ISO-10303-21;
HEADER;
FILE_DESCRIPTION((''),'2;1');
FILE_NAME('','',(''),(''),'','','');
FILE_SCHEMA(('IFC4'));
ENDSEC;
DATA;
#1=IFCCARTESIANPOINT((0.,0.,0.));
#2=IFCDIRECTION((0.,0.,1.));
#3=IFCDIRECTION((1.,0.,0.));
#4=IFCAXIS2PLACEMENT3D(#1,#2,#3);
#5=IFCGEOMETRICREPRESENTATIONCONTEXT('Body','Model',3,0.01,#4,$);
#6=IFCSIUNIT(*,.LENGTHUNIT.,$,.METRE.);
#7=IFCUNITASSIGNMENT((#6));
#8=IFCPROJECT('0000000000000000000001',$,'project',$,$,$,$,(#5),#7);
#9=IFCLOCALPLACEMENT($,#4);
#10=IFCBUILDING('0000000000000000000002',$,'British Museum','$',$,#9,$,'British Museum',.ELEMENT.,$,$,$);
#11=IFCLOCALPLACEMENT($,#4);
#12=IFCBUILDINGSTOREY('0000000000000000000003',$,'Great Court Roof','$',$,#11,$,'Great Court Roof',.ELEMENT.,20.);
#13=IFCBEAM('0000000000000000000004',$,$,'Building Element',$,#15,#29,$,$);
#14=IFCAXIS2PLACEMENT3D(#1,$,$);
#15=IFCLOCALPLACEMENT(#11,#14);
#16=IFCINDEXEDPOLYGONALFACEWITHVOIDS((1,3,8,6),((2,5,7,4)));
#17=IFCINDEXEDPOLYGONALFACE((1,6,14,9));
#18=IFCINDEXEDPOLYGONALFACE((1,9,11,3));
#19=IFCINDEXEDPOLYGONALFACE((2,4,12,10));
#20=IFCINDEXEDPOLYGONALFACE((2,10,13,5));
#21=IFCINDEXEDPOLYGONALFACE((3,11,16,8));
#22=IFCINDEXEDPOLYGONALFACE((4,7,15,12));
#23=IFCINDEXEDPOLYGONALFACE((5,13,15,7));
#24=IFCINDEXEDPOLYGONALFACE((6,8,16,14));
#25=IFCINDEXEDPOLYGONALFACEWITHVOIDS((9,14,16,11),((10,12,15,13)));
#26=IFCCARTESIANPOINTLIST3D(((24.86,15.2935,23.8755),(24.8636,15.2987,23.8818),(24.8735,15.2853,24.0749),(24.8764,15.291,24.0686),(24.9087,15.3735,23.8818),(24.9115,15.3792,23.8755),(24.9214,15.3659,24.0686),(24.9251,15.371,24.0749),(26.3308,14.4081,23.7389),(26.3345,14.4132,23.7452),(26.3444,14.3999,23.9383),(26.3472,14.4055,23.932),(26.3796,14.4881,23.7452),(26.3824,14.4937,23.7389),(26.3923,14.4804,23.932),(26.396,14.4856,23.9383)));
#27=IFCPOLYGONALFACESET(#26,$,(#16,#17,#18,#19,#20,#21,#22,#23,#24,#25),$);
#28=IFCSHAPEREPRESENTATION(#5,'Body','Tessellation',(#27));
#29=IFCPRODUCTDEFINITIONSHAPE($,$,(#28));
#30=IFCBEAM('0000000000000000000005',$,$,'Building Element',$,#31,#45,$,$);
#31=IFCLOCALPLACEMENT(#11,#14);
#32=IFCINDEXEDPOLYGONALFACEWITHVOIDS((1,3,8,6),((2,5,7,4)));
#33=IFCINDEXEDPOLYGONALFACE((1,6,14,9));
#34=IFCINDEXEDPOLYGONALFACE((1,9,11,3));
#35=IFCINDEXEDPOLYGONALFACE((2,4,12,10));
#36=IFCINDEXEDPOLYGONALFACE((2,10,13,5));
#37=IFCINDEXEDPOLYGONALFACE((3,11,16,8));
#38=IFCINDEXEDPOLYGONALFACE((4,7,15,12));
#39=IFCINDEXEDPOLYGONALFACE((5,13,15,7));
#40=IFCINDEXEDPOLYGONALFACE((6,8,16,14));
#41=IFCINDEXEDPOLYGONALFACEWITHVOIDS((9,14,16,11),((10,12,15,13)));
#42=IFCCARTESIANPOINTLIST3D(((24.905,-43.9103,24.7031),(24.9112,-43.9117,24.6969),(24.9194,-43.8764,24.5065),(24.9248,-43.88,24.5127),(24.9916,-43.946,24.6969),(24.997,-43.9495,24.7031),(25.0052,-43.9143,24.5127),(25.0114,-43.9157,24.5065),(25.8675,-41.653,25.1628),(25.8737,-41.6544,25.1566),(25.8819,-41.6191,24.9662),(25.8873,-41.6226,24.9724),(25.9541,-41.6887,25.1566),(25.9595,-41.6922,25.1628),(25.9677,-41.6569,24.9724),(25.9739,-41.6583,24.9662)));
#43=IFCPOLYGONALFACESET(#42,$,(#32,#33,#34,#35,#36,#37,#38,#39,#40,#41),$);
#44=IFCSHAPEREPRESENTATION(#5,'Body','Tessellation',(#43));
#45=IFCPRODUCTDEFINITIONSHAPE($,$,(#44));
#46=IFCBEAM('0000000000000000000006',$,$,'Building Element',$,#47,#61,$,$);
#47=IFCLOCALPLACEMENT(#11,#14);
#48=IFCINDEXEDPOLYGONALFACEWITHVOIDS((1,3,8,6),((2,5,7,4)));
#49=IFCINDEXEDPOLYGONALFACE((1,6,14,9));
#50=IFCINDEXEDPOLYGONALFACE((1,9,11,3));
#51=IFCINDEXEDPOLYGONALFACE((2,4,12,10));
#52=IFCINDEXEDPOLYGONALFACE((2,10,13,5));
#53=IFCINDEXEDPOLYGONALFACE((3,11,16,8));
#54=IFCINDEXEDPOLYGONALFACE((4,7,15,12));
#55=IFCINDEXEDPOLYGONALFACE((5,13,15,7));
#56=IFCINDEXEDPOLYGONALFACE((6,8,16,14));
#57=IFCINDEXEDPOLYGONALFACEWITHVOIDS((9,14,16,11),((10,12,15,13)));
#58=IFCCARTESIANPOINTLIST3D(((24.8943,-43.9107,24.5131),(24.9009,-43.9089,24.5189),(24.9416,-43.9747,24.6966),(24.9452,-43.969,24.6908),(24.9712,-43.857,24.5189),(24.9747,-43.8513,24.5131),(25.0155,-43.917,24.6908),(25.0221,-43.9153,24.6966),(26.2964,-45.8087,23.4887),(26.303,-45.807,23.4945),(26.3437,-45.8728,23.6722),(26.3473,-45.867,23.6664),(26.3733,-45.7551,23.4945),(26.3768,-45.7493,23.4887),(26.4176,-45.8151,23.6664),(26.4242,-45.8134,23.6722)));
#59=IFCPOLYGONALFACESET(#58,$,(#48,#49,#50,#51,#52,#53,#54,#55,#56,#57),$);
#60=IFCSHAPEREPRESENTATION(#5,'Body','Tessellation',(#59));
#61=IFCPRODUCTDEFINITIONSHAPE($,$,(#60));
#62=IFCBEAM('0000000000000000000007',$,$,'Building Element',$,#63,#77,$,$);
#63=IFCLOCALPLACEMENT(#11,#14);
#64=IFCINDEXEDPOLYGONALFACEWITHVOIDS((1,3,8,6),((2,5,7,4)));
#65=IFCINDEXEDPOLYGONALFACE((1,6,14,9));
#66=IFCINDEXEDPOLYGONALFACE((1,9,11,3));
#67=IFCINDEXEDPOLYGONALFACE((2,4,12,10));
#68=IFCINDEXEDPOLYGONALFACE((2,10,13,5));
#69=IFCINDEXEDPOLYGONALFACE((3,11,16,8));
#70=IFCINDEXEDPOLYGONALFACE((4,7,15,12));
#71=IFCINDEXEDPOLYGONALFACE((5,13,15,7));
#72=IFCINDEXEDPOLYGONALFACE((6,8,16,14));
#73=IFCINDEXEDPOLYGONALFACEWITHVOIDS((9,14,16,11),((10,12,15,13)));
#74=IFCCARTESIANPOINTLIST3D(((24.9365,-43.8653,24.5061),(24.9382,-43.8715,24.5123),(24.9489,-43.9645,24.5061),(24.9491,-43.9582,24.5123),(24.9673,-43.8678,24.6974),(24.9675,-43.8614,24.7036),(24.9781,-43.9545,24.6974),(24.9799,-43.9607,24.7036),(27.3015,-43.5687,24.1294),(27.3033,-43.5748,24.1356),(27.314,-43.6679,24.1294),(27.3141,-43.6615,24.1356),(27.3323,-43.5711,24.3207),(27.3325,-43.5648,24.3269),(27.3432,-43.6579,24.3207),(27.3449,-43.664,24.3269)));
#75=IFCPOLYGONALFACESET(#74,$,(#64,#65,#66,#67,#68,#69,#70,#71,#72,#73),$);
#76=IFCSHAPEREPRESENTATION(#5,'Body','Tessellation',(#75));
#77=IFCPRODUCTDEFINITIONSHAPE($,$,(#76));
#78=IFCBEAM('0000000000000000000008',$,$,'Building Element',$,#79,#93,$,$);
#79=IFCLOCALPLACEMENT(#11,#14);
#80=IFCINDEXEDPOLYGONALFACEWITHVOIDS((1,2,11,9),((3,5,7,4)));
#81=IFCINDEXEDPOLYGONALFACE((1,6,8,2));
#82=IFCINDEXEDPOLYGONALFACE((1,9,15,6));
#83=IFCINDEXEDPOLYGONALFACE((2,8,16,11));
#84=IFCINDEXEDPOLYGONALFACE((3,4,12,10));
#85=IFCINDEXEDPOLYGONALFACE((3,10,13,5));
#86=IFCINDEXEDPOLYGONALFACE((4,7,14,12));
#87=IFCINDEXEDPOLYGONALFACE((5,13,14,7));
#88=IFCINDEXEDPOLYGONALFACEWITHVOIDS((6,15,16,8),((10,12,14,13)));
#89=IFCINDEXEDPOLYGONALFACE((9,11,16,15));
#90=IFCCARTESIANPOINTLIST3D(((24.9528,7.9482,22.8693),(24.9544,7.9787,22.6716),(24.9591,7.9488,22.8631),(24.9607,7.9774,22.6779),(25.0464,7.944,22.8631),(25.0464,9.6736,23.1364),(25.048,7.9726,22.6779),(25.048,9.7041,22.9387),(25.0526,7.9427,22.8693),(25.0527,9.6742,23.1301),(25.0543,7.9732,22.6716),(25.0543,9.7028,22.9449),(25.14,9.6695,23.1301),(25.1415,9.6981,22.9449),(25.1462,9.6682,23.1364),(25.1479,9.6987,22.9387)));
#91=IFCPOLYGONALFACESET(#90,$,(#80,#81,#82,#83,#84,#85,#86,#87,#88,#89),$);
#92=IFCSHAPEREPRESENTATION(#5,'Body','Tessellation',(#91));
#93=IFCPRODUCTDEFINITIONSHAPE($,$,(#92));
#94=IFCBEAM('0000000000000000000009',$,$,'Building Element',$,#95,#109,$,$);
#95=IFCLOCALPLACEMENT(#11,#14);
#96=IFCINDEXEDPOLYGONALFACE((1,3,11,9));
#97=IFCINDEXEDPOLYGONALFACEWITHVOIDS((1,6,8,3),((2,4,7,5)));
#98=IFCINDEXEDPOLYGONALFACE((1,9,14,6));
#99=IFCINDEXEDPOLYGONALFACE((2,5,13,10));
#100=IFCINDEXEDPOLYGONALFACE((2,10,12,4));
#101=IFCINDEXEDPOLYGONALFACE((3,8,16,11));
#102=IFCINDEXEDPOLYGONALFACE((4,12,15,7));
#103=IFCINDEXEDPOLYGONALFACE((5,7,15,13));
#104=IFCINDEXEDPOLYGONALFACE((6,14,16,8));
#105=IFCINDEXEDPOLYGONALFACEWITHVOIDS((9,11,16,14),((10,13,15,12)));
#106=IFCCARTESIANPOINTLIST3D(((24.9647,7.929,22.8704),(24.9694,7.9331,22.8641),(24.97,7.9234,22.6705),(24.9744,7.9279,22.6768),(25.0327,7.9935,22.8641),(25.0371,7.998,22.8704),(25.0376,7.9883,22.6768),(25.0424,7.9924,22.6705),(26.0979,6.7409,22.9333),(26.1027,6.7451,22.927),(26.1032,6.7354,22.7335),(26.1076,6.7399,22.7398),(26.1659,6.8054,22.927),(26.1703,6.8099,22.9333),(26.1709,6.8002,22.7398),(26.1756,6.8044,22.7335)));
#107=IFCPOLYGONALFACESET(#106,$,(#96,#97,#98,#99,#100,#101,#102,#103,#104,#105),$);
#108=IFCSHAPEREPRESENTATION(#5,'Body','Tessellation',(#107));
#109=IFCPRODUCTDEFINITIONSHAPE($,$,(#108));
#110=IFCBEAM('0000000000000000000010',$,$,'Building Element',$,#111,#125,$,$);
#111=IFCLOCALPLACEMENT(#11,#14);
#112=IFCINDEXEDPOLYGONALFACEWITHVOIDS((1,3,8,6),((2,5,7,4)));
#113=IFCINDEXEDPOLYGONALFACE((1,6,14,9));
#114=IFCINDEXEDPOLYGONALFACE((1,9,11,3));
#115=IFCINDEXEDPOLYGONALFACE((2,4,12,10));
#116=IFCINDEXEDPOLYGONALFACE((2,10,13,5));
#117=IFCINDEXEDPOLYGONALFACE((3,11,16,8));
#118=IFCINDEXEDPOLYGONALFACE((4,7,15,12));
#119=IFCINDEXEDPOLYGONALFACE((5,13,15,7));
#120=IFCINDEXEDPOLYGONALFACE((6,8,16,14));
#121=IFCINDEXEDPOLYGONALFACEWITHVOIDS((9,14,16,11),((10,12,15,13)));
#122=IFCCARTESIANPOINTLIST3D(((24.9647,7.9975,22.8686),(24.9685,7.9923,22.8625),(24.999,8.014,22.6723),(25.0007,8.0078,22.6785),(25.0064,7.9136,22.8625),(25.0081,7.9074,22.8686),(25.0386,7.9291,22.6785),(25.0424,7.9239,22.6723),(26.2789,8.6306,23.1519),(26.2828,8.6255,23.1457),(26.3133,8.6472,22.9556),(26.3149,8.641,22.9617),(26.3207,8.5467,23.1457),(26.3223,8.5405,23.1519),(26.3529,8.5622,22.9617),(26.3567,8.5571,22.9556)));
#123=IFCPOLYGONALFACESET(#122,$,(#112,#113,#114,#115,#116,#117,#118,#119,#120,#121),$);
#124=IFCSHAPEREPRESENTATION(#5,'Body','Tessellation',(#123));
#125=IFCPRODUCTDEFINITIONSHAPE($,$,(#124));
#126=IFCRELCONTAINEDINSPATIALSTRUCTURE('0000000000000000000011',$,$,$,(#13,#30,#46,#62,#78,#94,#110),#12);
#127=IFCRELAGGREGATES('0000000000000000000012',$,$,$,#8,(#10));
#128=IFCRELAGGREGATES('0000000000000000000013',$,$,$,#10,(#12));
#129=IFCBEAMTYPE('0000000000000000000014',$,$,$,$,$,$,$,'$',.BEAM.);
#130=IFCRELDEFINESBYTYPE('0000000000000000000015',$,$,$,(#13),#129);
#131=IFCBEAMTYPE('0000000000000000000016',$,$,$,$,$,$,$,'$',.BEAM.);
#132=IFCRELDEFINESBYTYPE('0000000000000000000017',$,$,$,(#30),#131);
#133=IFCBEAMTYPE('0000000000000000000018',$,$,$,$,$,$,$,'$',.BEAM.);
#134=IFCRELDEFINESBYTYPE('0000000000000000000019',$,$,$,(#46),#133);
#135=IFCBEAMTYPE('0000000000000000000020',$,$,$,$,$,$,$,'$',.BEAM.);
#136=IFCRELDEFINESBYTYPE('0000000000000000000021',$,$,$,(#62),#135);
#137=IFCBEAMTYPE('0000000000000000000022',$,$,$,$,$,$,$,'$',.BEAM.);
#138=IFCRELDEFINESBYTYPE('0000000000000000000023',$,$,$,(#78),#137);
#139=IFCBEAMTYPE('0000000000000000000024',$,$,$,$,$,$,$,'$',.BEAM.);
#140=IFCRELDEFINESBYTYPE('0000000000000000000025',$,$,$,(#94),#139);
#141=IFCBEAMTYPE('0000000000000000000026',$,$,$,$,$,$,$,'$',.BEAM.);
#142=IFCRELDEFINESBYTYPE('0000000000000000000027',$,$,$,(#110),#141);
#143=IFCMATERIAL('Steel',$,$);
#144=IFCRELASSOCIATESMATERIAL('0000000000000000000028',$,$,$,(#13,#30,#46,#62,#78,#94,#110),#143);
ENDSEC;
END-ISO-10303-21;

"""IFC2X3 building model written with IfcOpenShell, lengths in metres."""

from ifc_helpers import new_model, si_unit, frame, origin_with_axes, origin_2d, place, context, project, spatial, hollow_rectangle, extrude, material, type_object, element, save


model = new_model("IFC2X3")

# Units and contexts
model_context = context("Model", 3, precision=0.01, world=origin_with_axes(), identifier="Body")
ifc_project = project(units=[si_unit("LENGTHUNIT", "METRE")], contexts=[model_context])

# Building, storey
building_placement = place(None, origin_with_axes())
building = spatial("IfcBuilding", under=ifc_project, at=building_placement, Name="British Museum", Description="$", LongName="British Museum", CompositionType="ELEMENT")
storey_placement = place(None, origin_with_axes())
storey = spatial("IfcBuildingStorey", under=building, at=storey_placement, Name="Great Court Roof", Description="$", LongName="Great Court Roof", CompositionType="ELEMENT", Elevation=20.0)

# Beams
ifc_material = material(Name="Steel")
beam_type_1 = type_object("IfcBeamType", ElementType="$", PredefinedType="BEAM")
beam_1_placement = place(None, origin_with_axes())
element("IfcBeam", 1, at=beam_1_placement, inside=storey, type_object=beam_type_1, material=ifc_material, Description="Building Element", context=model_context, shape_type="SweptSolid", body=[
    extrude(hollow_rectangle(XDim=0.1, YDim=0.2, WallThickness=0.0063, InnerFilletRadius=-0.0063, OuterFilletRadius=0.0, at=origin_2d()), frame((24.8925, 15.3323, 23.9752), z_axis=(0.85404, -0.514127, -0.079308), x_axis=(0.515752, 0.856738, 0.0)), (0.0, 0.0, 1.0), 1.7222),
])
beam_type_2 = type_object("IfcBeamType", ElementType="$", PredefinedType="BEAM")
beam_2_placement = place(None, origin_with_axes())
element("IfcBeam", 2, at=beam_2_placement, inside=storey, type_object=beam_type_2, material=ifc_material, Description="Building Element", context=model_context, shape_type="SweptSolid", body=[
    extrude(hollow_rectangle(XDim=0.1, YDim=0.2, WallThickness=0.0063, InnerFilletRadius=-0.0063, OuterFilletRadius=0.0, at=origin_2d()), frame((24.9582, -43.913, 24.6048), z_axis=(0.385525, 0.904145, 0.1841), x_axis=(-0.919868, 0.392229, 0.0)), (0.0, 0.0, 1.0), 2.4967),
])
beam_type_3 = type_object("IfcBeamType", ElementType="$", PredefinedType="BEAM")
beam_3_placement = place(None, origin_with_axes())
element("IfcBeam", 3, at=beam_3_placement, inside=storey, type_object=beam_type_3, material=ifc_material, Description="Building Element", context=model_context, shape_type="SweptSolid", body=[
    extrude(hollow_rectangle(XDim=0.1, YDim=0.2, WallThickness=0.0063, InnerFilletRadius=-0.0063, OuterFilletRadius=0.0, at=origin_2d()), frame((24.9582, -43.913, 24.6048), z_axis=(0.545026, -0.737824, -0.398199), x_axis=(0.804344, 0.594164, 0.0)), (0.0, 0.0, 1.0), 2.5725),
])
beam_type_4 = type_object("IfcBeamType", ElementType="$", PredefinedType="BEAM")
beam_4_placement = place(None, origin_with_axes())
element("IfcBeam", 4, at=beam_4_placement, inside=storey, type_object=beam_type_4, material=ifc_material, Description="Building Element", context=model_context, shape_type="SweptSolid", body=[
    extrude(hollow_rectangle(XDim=0.1, YDim=0.2, WallThickness=0.0063, InnerFilletRadius=-0.0063, OuterFilletRadius=0.0, at=origin_2d()), frame((24.9582, -43.913, 24.6048), z_axis=(0.980063, 0.122939, -0.156086), x_axis=(-0.124465, 0.992224, 0.0)), (0.0, 0.0, 1.0), 2.4131),
])
beam_type_5 = type_object("IfcBeamType", ElementType="$", PredefinedType="BEAM")
beam_5_placement = place(None, origin_with_axes())
element("IfcBeam", 5, at=beam_5_placement, inside=storey, type_object=beam_type_5, material=ifc_material, Description="Building Element", context=model_context, shape_type="SweptSolid", body=[
    extrude(hollow_rectangle(XDim=0.1, YDim=0.2, WallThickness=0.0063, InnerFilletRadius=-0.0063, OuterFilletRadius=0.0, at=origin_2d()), frame((25.0035, 7.9607, 22.7705), z_axis=(0.053519, 0.986817, 0.152737), x_axis=(-0.998533, 0.054155, 0.0)), (0.0, 0.0, 1.0), 1.7485),
])
beam_type_6 = type_object("IfcBeamType", ElementType="$", PredefinedType="BEAM")
beam_6_placement = place(None, origin_with_axes())
element("IfcBeam", 6, at=beam_6_placement, inside=storey, type_object=beam_type_6, material=ifc_material, Description="Building Element", context=model_context, shape_type="SweptSolid", body=[
    extrude(hollow_rectangle(XDim=0.1, YDim=0.2, WallThickness=0.0063, InnerFilletRadius=-0.0063, OuterFilletRadius=0.0, at=origin_2d()), frame((25.0035, 7.9607, 22.7705), z_axis=(0.689695, -0.723086, 0.038293), x_axis=(0.723617, 0.690202, 0.0)), (0.0, 0.0, 1.0), 1.6431),
])
beam_type_7 = type_object("IfcBeamType", ElementType="$", PredefinedType="BEAM")
beam_7_placement = place(None, origin_with_axes())
element("IfcBeam", 7, at=beam_7_placement, inside=storey, type_object=beam_type_7, material=ifc_material, Description="Building Element", context=model_context, shape_type="SweptSolid", body=[
    extrude(hollow_rectangle(XDim=0.1, YDim=0.2, WallThickness=0.0063, InnerFilletRadius=-0.0063, OuterFilletRadius=0.0, at=origin_2d()), frame((25.0035, 7.9607, 22.7705), z_axis=(0.884395, 0.426045, 0.190609), x_axis=(-0.434002, 0.900912, 0.0)), (0.0, 0.0, 1.0), 1.4861),
])

save(model, "model.ifc")
